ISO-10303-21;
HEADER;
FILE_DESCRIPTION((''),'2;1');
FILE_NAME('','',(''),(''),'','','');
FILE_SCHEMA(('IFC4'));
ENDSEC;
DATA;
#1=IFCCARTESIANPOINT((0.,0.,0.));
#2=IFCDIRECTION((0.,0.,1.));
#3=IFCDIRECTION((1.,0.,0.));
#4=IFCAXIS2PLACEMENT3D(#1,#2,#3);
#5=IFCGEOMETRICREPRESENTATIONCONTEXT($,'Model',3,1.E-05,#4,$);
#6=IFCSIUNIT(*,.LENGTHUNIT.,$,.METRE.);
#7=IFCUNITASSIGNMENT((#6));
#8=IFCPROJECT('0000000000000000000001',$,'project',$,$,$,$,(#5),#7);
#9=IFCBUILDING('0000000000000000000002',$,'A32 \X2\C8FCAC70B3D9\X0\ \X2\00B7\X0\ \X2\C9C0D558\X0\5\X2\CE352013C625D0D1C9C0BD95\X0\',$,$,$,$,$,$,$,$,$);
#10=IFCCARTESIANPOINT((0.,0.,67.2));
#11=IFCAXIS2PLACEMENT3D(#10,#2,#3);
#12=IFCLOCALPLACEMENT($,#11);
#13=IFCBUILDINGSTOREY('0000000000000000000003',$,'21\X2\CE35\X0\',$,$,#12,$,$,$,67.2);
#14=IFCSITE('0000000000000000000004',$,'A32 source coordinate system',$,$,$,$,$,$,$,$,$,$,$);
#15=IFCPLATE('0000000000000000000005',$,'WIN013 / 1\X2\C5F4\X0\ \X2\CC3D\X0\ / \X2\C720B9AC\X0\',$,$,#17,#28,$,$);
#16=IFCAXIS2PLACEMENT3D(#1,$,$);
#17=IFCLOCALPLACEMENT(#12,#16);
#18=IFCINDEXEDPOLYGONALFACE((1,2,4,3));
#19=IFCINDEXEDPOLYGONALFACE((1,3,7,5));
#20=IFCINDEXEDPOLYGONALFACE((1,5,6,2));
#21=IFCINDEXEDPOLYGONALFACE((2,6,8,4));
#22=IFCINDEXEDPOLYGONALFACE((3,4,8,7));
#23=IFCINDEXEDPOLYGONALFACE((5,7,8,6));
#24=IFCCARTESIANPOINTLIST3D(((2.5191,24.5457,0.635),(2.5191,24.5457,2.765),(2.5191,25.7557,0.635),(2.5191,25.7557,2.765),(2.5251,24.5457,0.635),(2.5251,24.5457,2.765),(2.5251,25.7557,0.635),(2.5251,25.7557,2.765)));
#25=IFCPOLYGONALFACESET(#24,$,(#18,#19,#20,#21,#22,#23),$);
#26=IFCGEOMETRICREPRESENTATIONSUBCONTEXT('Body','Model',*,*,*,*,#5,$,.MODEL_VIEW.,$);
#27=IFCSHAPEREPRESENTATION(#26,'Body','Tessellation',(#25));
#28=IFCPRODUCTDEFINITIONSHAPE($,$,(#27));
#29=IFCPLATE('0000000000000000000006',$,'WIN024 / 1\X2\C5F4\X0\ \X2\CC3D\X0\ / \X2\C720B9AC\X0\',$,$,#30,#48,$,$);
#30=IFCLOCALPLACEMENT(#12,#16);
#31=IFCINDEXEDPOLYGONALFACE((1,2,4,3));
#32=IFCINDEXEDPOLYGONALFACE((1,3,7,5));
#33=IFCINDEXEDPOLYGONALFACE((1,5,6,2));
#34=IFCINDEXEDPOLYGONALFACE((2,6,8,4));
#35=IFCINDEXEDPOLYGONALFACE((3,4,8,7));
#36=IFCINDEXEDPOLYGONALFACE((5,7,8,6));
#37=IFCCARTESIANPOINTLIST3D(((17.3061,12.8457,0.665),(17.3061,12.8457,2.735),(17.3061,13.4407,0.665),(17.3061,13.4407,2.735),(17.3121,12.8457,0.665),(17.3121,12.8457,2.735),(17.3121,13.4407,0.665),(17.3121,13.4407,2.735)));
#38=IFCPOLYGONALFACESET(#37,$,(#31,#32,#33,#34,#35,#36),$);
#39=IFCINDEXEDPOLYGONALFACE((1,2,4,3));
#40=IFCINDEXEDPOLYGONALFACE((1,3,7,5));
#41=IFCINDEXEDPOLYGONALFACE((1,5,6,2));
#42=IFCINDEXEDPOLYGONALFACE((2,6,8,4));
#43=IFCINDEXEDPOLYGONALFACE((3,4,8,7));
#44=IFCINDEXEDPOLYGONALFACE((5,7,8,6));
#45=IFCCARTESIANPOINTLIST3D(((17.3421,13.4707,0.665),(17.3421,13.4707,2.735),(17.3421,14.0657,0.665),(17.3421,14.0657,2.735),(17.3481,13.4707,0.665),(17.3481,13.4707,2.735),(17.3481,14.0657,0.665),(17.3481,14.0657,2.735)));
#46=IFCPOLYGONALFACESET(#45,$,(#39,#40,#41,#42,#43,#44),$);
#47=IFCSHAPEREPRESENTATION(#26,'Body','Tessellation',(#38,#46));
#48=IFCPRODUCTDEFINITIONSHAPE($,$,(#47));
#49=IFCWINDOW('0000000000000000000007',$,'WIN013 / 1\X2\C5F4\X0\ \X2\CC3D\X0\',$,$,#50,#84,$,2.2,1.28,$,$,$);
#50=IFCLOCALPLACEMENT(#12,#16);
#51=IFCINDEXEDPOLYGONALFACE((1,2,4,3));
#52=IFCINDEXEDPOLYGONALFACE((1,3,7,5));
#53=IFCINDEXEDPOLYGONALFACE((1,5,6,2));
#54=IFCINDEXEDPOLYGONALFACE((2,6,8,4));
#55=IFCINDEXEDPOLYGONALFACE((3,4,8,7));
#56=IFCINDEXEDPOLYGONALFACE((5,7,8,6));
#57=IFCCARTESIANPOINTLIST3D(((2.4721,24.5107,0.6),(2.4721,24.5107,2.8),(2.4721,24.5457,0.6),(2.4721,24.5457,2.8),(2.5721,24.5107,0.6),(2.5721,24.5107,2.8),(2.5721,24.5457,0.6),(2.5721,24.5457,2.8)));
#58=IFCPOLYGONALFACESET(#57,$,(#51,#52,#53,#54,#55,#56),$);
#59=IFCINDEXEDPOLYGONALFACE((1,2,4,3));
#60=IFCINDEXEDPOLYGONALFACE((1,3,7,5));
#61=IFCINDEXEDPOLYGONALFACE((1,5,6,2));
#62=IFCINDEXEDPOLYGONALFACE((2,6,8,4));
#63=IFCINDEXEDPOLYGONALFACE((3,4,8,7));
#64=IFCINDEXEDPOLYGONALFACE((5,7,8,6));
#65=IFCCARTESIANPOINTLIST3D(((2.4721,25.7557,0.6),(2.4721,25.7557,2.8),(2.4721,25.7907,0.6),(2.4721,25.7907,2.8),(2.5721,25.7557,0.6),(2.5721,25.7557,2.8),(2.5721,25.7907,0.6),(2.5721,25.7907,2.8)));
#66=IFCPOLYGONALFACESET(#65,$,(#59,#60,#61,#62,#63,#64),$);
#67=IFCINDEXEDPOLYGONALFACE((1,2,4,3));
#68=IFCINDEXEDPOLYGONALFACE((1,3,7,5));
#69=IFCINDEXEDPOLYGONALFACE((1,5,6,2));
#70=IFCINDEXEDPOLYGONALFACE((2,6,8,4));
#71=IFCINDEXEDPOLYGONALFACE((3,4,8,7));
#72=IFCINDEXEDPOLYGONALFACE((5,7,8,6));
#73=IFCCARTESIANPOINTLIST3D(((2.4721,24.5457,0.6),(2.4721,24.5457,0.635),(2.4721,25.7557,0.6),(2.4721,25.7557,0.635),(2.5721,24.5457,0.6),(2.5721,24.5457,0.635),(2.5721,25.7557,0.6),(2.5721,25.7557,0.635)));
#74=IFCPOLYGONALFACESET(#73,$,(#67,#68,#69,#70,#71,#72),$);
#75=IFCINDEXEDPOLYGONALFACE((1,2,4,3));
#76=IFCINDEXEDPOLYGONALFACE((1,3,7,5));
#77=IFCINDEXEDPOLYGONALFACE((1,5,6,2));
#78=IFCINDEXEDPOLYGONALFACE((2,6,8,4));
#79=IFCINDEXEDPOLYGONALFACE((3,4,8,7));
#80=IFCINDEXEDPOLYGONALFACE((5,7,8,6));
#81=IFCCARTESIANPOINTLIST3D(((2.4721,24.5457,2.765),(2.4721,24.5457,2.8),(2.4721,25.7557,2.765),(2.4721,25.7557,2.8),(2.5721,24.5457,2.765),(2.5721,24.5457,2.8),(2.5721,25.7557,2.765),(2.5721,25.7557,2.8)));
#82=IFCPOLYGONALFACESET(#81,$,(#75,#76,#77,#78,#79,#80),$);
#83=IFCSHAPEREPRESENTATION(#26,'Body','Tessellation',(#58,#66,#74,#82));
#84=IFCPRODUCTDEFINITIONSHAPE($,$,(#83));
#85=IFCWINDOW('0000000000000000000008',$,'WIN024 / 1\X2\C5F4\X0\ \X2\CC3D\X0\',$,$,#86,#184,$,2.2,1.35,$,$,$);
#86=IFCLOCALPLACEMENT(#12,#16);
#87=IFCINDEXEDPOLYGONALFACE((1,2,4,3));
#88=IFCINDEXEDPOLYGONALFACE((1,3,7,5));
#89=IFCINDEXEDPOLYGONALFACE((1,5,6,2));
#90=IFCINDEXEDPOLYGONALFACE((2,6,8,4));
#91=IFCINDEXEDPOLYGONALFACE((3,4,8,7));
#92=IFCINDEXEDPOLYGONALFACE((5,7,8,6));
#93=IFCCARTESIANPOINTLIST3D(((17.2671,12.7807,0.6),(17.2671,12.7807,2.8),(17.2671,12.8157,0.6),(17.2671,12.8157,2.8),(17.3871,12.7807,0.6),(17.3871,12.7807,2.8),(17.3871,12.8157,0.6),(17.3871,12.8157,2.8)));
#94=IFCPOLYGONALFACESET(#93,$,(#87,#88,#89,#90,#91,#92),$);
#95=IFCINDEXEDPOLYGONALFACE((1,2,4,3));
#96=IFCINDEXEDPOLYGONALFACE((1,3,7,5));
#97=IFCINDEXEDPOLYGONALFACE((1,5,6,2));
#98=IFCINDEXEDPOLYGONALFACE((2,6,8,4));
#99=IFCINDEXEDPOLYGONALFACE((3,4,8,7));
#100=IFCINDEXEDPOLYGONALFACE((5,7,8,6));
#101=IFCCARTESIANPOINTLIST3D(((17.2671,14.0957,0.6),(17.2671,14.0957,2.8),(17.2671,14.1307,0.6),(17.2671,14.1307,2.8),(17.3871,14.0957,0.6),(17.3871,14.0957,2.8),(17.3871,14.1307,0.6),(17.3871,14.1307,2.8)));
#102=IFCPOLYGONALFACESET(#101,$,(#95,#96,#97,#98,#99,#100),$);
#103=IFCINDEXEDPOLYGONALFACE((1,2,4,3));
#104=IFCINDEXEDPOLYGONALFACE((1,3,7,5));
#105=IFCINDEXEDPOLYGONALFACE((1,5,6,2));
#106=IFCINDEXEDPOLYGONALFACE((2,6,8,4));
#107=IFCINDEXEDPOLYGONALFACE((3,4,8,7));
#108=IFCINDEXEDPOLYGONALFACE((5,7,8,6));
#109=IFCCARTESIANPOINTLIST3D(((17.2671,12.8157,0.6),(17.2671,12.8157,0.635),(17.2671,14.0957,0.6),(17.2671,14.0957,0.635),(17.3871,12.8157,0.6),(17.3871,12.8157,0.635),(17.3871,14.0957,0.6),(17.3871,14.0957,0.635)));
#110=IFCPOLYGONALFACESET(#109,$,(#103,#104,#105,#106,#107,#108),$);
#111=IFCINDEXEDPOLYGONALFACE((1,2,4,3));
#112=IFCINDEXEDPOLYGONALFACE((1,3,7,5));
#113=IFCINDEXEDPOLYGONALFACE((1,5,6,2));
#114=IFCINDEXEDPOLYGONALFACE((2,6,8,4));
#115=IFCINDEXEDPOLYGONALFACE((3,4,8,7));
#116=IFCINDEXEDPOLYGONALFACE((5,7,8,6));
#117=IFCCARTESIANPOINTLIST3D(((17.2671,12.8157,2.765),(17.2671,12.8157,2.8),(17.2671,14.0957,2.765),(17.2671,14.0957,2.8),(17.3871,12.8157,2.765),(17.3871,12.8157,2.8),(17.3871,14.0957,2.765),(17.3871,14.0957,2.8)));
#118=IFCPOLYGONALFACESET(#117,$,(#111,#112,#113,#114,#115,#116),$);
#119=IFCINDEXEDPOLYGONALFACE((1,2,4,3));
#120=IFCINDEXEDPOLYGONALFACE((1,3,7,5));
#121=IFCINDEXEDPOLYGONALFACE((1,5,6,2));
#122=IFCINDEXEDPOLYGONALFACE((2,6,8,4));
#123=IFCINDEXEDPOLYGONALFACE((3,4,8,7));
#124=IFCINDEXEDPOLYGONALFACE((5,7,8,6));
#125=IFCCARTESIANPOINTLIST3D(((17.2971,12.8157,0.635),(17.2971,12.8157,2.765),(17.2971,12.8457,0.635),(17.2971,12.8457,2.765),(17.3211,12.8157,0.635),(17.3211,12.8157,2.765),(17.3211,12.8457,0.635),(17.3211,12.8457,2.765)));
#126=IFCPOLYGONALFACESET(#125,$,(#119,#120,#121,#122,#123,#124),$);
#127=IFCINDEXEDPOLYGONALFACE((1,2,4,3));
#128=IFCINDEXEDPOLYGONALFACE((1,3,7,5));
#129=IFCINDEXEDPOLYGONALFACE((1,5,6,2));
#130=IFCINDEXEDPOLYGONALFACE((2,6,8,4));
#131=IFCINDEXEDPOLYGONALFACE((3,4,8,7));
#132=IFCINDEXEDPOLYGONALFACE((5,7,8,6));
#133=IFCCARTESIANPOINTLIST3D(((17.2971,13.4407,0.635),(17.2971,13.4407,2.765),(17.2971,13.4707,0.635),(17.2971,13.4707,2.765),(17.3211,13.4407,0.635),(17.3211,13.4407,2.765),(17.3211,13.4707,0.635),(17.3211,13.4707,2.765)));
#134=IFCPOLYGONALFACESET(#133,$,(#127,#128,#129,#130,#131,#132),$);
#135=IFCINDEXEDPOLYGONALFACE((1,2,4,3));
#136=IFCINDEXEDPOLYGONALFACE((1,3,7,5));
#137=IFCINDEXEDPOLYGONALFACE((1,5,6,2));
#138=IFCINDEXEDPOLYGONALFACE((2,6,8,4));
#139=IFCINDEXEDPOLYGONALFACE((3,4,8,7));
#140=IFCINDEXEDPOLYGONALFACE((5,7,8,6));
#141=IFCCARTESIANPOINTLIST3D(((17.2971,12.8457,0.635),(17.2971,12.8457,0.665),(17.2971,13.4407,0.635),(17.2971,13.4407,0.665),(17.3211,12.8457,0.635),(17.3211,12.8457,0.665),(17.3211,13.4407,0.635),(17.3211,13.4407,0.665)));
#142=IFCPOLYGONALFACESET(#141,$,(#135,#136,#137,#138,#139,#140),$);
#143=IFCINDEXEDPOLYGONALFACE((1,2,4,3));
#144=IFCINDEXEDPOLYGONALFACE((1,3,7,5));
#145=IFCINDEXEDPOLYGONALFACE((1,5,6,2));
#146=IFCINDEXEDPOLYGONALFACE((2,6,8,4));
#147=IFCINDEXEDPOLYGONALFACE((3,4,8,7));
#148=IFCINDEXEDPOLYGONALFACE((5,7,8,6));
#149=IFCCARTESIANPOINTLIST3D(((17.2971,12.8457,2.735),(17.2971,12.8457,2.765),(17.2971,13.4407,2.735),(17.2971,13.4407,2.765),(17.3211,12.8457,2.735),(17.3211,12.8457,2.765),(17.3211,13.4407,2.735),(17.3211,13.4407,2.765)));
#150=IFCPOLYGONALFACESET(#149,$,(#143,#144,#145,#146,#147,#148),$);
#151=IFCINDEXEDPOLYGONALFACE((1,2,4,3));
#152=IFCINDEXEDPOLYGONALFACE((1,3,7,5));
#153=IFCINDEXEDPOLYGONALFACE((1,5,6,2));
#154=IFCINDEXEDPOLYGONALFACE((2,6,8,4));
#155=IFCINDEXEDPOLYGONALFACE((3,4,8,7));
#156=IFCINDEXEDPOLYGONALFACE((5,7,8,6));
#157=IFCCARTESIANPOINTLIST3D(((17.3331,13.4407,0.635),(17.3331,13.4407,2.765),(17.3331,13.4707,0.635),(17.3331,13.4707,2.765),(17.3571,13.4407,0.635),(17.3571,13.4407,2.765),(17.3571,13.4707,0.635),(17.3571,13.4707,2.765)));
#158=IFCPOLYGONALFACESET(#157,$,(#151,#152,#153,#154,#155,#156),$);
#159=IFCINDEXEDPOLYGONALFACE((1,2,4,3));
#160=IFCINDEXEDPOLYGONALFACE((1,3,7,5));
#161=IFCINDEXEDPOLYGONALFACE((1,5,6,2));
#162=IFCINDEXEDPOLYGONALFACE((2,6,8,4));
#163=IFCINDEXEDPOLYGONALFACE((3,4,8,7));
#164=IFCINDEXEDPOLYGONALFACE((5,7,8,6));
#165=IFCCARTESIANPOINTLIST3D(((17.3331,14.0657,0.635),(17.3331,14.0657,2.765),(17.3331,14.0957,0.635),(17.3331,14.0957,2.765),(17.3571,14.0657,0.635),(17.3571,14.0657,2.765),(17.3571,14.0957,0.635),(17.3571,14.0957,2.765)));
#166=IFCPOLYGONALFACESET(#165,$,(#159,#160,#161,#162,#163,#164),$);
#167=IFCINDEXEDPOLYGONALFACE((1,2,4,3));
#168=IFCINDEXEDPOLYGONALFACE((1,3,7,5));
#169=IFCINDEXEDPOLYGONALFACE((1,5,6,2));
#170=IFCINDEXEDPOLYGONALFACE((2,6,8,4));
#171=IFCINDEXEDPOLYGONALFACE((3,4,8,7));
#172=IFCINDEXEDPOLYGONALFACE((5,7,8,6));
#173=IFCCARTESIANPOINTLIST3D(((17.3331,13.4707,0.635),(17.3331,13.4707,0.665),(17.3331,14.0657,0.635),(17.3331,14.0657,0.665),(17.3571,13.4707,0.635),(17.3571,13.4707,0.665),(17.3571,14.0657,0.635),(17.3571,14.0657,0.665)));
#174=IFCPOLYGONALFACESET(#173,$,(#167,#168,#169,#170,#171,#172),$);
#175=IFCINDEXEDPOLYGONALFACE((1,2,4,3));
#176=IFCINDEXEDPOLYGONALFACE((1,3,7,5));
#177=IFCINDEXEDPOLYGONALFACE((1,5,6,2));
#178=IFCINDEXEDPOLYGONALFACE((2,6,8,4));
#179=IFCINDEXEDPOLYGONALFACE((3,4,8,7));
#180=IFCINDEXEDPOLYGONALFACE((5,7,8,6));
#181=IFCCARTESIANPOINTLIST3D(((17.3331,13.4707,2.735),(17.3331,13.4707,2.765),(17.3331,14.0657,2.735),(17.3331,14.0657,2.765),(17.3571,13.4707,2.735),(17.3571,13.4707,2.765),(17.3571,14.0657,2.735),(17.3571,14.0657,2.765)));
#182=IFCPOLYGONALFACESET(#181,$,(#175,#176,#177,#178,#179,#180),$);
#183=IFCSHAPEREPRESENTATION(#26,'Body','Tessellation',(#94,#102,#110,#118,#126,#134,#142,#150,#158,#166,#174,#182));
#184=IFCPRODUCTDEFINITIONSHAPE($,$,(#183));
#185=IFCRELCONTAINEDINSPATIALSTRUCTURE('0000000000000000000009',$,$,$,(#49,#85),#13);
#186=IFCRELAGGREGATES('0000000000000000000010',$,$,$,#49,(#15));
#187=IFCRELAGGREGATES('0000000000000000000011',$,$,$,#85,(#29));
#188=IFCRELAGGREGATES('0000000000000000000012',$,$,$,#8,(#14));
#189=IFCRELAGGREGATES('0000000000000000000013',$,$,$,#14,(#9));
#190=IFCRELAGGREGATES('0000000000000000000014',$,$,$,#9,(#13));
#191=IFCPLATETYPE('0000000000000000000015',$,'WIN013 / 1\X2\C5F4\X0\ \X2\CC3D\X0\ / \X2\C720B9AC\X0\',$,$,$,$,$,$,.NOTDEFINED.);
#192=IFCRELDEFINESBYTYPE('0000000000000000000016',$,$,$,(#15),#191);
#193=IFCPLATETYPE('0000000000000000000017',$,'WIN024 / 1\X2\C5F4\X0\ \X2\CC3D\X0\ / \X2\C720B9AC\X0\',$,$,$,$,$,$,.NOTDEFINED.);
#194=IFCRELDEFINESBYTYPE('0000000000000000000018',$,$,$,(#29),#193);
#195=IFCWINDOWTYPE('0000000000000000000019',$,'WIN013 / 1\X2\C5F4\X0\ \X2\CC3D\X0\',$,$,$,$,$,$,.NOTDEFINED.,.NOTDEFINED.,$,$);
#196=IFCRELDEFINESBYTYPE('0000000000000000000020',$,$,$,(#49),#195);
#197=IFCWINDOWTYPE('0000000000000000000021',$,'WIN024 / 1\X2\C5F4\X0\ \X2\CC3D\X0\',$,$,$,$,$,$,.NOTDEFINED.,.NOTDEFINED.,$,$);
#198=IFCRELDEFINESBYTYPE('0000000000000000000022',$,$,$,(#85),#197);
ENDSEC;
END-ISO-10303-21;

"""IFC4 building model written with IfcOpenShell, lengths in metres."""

from ifc_helpers import new_model, si_unit, frame, origin, origin_with_axes, place, context, subcontext, project, spatial, polyline, outline, extrude, source, transform, mapped, type_object, type_shapes, element, aggregate, save


model = new_model("IFC4")

# Units and contexts
model_context = context("Model", 3, precision=1e-05, world=origin_with_axes())
body_context = subcontext(model_context, "Body", "Model", "MODEL_VIEW")
ifc_project = project(units=[si_unit("LENGTHUNIT", "METRE")], contexts=[model_context])

# Plates
plate_type_1 = type_object("IfcPlateType", Name="WIN013 / 1열 창 / 유리", PredefinedType="NOTDEFINED")
shared_shape_1 = source(origin(), body_context, "Body", "SweptSolid", [
    extrude(outline(polyline([(2.5191, 24.5457), (2.5191, 25.7557), (2.5251, 25.7557), (2.5251, 24.5457), (2.5191, 24.5457)])), frame((0.0, 0.0, 0.635)), (0.0, 0.0, 1.0), 2.13),
])
type_shapes(plate_type_1, [shared_shape_1])
storey_placement = place(None, frame((0.0, 0.0, 67.2), z_axis=(0.0, 0.0, 1.0), x_axis=(1.0, 0.0, 0.0)))
window_1_placement = place(storey_placement, origin_with_axes())
plate_1_placement = place(window_1_placement, origin_with_axes())
plate_1 = element("IfcPlate", 1, at=plate_1_placement, type_object=plate_type_1, Name="WIN013 / 1열 창 / 유리", context=body_context, shape_type="MappedRepresentation", body=[
    mapped(shared_shape_1, transform((0.0, 0.0, 0.0), scale=1.0)),
])
plate_type_2 = type_object("IfcPlateType", Name="WIN024 / 1열 창 / 유리", PredefinedType="NOTDEFINED")
shared_shape_2 = source(origin(), body_context, "Body", "SweptSolid", [
    extrude(outline(polyline([(17.3061, 12.8457), (17.3061, 13.4407), (17.3121, 13.4407), (17.3121, 12.8457), (17.3061, 12.8457)])), frame((0.0, 0.0, 0.665)), (0.0, 0.0, 1.0), 2.07),
    extrude(outline(polyline([(17.3421, 13.4707), (17.3421, 14.0657), (17.3481, 14.0657), (17.3481, 13.4707), (17.3421, 13.4707)])), frame((0.0, 0.0, 0.665)), (0.0, 0.0, 1.0), 2.07),
])
type_shapes(plate_type_2, [shared_shape_2])
window_2_placement = place(storey_placement, origin_with_axes())
plate_2_placement = place(window_2_placement, origin_with_axes())
plate_2 = element("IfcPlate", 2, at=plate_2_placement, type_object=plate_type_2, Name="WIN024 / 1열 창 / 유리", context=body_context, shape_type="MappedRepresentation", body=[
    mapped(shared_shape_2, transform((0.0, 0.0, 0.0), scale=1.0)),
])

# Site, building, storey
site = spatial("IfcSite", under=ifc_project, Name="A32 source coordinate system")
building = spatial("IfcBuilding", under=site, Name="A32 주거동 · 지하5층–옥탑지붕")
storey = spatial("IfcBuildingStorey", under=building, at=storey_placement, Name="21층", Elevation=67.2)

# Windows
window_type_1 = type_object("IfcWindowType", Name="WIN013 / 1열 창", PartitioningType="NOTDEFINED", PredefinedType="NOTDEFINED")
shared_shape_3 = source(origin(), body_context, "Body", "SweptSolid", [
    extrude(outline(polyline([(2.4721, 24.5107), (2.4721, 24.5457), (2.5721, 24.5457), (2.5721, 24.5107), (2.4721, 24.5107)])), frame((0.0, 0.0, 0.6)), (0.0, 0.0, 1.0), 2.2),
    extrude(outline(polyline([(2.4721, 25.7557), (2.4721, 25.7907), (2.5721, 25.7907), (2.5721, 25.7557), (2.4721, 25.7557)])), frame((0.0, 0.0, 0.6)), (0.0, 0.0, 1.0), 2.2),
    extrude(outline(polyline([(2.4721, 24.5457), (2.4721, 25.7557), (2.5721, 25.7557), (2.5721, 24.5457), (2.4721, 24.5457)])), frame((0.0, 0.0, 0.6)), (0.0, 0.0, 1.0), 0.035),
    extrude(outline(polyline([(2.4721, 24.5457), (2.4721, 25.7557), (2.5721, 25.7557), (2.5721, 24.5457), (2.4721, 24.5457)])), frame((0.0, 0.0, 2.765)), (0.0, 0.0, 1.0), 0.035),
])
type_shapes(window_type_1, [shared_shape_3])
window_1 = element("IfcWindow", 3, at=window_1_placement, inside=storey, type_object=window_type_1, Name="WIN013 / 1열 창", OverallHeight=2.2, OverallWidth=1.28, context=body_context, shape_type="MappedRepresentation", body=[
    mapped(shared_shape_3, transform((0.0, 0.0, 0.0), scale=1.0)),
])
aggregate(window_1, [plate_1])
window_type_2 = type_object("IfcWindowType", Name="WIN024 / 1열 창", PartitioningType="NOTDEFINED", PredefinedType="NOTDEFINED")
shared_shape_4 = source(origin(), body_context, "Body", "SweptSolid", [
    extrude(outline(polyline([(17.2671, 12.7807), (17.2671, 12.8157), (17.3871, 12.8157), (17.3871, 12.7807), (17.2671, 12.7807)])), frame((0.0, 0.0, 0.6)), (0.0, 0.0, 1.0), 2.2),
    extrude(outline(polyline([(17.2671, 14.0957), (17.2671, 14.1307), (17.3871, 14.1307), (17.3871, 14.0957), (17.2671, 14.0957)])), frame((0.0, 0.0, 0.6)), (0.0, 0.0, 1.0), 2.2),
    extrude(outline(polyline([(17.2671, 12.8157), (17.2671, 14.0957), (17.3871, 14.0957), (17.3871, 12.8157), (17.2671, 12.8157)])), frame((0.0, 0.0, 0.6)), (0.0, 0.0, 1.0), 0.035),
    extrude(outline(polyline([(17.2671, 12.8157), (17.2671, 14.0957), (17.3871, 14.0957), (17.3871, 12.8157), (17.2671, 12.8157)])), frame((0.0, 0.0, 2.765)), (0.0, 0.0, 1.0), 0.035),
    extrude(outline(polyline([(17.2971, 12.8157), (17.2971, 12.8457), (17.3211, 12.8457), (17.3211, 12.8157), (17.2971, 12.8157)])), frame((0.0, 0.0, 0.635)), (0.0, 0.0, 1.0), 2.13),
    extrude(outline(polyline([(17.2971, 13.4407), (17.2971, 13.4707), (17.3211, 13.4707), (17.3211, 13.4407), (17.2971, 13.4407)])), frame((0.0, 0.0, 0.635)), (0.0, 0.0, 1.0), 2.13),
    extrude(outline(polyline([(17.2971, 12.8457), (17.2971, 13.4407), (17.3211, 13.4407), (17.3211, 12.8457), (17.2971, 12.8457)])), frame((0.0, 0.0, 0.635)), (0.0, 0.0, 1.0), 0.03),
    extrude(outline(polyline([(17.2971, 12.8457), (17.2971, 13.4407), (17.3211, 13.4407), (17.3211, 12.8457), (17.2971, 12.8457)])), frame((0.0, 0.0, 2.735)), (0.0, 0.0, 1.0), 0.03),
    extrude(outline(polyline([(17.3331, 13.4407), (17.3331, 13.4707), (17.3571, 13.4707), (17.3571, 13.4407), (17.3331, 13.4407)])), frame((0.0, 0.0, 0.635)), (0.0, 0.0, 1.0), 2.13),
    extrude(outline(polyline([(17.3331, 14.0657), (17.3331, 14.0957), (17.3571, 14.0957), (17.3571, 14.0657), (17.3331, 14.0657)])), frame((0.0, 0.0, 0.635)), (0.0, 0.0, 1.0), 2.13),
    extrude(outline(polyline([(17.3331, 13.4707), (17.3331, 14.0657), (17.3571, 14.0657), (17.3571, 13.4707), (17.3331, 13.4707)])), frame((0.0, 0.0, 0.635)), (0.0, 0.0, 1.0), 0.03),
    extrude(outline(polyline([(17.3331, 13.4707), (17.3331, 14.0657), (17.3571, 14.0657), (17.3571, 13.4707), (17.3331, 13.4707)])), frame((0.0, 0.0, 2.735)), (0.0, 0.0, 1.0), 0.03),
])
type_shapes(window_type_2, [shared_shape_4])
window_2 = element("IfcWindow", 4, at=window_2_placement, inside=storey, type_object=window_type_2, Name="WIN024 / 1열 창", OverallHeight=2.2, OverallWidth=1.35, context=body_context, shape_type="MappedRepresentation", body=[
    mapped(shared_shape_4, transform((0.0, 0.0, 0.0), scale=1.0)),
])
aggregate(window_2, [plate_2])

save(model, "model.ifc")
